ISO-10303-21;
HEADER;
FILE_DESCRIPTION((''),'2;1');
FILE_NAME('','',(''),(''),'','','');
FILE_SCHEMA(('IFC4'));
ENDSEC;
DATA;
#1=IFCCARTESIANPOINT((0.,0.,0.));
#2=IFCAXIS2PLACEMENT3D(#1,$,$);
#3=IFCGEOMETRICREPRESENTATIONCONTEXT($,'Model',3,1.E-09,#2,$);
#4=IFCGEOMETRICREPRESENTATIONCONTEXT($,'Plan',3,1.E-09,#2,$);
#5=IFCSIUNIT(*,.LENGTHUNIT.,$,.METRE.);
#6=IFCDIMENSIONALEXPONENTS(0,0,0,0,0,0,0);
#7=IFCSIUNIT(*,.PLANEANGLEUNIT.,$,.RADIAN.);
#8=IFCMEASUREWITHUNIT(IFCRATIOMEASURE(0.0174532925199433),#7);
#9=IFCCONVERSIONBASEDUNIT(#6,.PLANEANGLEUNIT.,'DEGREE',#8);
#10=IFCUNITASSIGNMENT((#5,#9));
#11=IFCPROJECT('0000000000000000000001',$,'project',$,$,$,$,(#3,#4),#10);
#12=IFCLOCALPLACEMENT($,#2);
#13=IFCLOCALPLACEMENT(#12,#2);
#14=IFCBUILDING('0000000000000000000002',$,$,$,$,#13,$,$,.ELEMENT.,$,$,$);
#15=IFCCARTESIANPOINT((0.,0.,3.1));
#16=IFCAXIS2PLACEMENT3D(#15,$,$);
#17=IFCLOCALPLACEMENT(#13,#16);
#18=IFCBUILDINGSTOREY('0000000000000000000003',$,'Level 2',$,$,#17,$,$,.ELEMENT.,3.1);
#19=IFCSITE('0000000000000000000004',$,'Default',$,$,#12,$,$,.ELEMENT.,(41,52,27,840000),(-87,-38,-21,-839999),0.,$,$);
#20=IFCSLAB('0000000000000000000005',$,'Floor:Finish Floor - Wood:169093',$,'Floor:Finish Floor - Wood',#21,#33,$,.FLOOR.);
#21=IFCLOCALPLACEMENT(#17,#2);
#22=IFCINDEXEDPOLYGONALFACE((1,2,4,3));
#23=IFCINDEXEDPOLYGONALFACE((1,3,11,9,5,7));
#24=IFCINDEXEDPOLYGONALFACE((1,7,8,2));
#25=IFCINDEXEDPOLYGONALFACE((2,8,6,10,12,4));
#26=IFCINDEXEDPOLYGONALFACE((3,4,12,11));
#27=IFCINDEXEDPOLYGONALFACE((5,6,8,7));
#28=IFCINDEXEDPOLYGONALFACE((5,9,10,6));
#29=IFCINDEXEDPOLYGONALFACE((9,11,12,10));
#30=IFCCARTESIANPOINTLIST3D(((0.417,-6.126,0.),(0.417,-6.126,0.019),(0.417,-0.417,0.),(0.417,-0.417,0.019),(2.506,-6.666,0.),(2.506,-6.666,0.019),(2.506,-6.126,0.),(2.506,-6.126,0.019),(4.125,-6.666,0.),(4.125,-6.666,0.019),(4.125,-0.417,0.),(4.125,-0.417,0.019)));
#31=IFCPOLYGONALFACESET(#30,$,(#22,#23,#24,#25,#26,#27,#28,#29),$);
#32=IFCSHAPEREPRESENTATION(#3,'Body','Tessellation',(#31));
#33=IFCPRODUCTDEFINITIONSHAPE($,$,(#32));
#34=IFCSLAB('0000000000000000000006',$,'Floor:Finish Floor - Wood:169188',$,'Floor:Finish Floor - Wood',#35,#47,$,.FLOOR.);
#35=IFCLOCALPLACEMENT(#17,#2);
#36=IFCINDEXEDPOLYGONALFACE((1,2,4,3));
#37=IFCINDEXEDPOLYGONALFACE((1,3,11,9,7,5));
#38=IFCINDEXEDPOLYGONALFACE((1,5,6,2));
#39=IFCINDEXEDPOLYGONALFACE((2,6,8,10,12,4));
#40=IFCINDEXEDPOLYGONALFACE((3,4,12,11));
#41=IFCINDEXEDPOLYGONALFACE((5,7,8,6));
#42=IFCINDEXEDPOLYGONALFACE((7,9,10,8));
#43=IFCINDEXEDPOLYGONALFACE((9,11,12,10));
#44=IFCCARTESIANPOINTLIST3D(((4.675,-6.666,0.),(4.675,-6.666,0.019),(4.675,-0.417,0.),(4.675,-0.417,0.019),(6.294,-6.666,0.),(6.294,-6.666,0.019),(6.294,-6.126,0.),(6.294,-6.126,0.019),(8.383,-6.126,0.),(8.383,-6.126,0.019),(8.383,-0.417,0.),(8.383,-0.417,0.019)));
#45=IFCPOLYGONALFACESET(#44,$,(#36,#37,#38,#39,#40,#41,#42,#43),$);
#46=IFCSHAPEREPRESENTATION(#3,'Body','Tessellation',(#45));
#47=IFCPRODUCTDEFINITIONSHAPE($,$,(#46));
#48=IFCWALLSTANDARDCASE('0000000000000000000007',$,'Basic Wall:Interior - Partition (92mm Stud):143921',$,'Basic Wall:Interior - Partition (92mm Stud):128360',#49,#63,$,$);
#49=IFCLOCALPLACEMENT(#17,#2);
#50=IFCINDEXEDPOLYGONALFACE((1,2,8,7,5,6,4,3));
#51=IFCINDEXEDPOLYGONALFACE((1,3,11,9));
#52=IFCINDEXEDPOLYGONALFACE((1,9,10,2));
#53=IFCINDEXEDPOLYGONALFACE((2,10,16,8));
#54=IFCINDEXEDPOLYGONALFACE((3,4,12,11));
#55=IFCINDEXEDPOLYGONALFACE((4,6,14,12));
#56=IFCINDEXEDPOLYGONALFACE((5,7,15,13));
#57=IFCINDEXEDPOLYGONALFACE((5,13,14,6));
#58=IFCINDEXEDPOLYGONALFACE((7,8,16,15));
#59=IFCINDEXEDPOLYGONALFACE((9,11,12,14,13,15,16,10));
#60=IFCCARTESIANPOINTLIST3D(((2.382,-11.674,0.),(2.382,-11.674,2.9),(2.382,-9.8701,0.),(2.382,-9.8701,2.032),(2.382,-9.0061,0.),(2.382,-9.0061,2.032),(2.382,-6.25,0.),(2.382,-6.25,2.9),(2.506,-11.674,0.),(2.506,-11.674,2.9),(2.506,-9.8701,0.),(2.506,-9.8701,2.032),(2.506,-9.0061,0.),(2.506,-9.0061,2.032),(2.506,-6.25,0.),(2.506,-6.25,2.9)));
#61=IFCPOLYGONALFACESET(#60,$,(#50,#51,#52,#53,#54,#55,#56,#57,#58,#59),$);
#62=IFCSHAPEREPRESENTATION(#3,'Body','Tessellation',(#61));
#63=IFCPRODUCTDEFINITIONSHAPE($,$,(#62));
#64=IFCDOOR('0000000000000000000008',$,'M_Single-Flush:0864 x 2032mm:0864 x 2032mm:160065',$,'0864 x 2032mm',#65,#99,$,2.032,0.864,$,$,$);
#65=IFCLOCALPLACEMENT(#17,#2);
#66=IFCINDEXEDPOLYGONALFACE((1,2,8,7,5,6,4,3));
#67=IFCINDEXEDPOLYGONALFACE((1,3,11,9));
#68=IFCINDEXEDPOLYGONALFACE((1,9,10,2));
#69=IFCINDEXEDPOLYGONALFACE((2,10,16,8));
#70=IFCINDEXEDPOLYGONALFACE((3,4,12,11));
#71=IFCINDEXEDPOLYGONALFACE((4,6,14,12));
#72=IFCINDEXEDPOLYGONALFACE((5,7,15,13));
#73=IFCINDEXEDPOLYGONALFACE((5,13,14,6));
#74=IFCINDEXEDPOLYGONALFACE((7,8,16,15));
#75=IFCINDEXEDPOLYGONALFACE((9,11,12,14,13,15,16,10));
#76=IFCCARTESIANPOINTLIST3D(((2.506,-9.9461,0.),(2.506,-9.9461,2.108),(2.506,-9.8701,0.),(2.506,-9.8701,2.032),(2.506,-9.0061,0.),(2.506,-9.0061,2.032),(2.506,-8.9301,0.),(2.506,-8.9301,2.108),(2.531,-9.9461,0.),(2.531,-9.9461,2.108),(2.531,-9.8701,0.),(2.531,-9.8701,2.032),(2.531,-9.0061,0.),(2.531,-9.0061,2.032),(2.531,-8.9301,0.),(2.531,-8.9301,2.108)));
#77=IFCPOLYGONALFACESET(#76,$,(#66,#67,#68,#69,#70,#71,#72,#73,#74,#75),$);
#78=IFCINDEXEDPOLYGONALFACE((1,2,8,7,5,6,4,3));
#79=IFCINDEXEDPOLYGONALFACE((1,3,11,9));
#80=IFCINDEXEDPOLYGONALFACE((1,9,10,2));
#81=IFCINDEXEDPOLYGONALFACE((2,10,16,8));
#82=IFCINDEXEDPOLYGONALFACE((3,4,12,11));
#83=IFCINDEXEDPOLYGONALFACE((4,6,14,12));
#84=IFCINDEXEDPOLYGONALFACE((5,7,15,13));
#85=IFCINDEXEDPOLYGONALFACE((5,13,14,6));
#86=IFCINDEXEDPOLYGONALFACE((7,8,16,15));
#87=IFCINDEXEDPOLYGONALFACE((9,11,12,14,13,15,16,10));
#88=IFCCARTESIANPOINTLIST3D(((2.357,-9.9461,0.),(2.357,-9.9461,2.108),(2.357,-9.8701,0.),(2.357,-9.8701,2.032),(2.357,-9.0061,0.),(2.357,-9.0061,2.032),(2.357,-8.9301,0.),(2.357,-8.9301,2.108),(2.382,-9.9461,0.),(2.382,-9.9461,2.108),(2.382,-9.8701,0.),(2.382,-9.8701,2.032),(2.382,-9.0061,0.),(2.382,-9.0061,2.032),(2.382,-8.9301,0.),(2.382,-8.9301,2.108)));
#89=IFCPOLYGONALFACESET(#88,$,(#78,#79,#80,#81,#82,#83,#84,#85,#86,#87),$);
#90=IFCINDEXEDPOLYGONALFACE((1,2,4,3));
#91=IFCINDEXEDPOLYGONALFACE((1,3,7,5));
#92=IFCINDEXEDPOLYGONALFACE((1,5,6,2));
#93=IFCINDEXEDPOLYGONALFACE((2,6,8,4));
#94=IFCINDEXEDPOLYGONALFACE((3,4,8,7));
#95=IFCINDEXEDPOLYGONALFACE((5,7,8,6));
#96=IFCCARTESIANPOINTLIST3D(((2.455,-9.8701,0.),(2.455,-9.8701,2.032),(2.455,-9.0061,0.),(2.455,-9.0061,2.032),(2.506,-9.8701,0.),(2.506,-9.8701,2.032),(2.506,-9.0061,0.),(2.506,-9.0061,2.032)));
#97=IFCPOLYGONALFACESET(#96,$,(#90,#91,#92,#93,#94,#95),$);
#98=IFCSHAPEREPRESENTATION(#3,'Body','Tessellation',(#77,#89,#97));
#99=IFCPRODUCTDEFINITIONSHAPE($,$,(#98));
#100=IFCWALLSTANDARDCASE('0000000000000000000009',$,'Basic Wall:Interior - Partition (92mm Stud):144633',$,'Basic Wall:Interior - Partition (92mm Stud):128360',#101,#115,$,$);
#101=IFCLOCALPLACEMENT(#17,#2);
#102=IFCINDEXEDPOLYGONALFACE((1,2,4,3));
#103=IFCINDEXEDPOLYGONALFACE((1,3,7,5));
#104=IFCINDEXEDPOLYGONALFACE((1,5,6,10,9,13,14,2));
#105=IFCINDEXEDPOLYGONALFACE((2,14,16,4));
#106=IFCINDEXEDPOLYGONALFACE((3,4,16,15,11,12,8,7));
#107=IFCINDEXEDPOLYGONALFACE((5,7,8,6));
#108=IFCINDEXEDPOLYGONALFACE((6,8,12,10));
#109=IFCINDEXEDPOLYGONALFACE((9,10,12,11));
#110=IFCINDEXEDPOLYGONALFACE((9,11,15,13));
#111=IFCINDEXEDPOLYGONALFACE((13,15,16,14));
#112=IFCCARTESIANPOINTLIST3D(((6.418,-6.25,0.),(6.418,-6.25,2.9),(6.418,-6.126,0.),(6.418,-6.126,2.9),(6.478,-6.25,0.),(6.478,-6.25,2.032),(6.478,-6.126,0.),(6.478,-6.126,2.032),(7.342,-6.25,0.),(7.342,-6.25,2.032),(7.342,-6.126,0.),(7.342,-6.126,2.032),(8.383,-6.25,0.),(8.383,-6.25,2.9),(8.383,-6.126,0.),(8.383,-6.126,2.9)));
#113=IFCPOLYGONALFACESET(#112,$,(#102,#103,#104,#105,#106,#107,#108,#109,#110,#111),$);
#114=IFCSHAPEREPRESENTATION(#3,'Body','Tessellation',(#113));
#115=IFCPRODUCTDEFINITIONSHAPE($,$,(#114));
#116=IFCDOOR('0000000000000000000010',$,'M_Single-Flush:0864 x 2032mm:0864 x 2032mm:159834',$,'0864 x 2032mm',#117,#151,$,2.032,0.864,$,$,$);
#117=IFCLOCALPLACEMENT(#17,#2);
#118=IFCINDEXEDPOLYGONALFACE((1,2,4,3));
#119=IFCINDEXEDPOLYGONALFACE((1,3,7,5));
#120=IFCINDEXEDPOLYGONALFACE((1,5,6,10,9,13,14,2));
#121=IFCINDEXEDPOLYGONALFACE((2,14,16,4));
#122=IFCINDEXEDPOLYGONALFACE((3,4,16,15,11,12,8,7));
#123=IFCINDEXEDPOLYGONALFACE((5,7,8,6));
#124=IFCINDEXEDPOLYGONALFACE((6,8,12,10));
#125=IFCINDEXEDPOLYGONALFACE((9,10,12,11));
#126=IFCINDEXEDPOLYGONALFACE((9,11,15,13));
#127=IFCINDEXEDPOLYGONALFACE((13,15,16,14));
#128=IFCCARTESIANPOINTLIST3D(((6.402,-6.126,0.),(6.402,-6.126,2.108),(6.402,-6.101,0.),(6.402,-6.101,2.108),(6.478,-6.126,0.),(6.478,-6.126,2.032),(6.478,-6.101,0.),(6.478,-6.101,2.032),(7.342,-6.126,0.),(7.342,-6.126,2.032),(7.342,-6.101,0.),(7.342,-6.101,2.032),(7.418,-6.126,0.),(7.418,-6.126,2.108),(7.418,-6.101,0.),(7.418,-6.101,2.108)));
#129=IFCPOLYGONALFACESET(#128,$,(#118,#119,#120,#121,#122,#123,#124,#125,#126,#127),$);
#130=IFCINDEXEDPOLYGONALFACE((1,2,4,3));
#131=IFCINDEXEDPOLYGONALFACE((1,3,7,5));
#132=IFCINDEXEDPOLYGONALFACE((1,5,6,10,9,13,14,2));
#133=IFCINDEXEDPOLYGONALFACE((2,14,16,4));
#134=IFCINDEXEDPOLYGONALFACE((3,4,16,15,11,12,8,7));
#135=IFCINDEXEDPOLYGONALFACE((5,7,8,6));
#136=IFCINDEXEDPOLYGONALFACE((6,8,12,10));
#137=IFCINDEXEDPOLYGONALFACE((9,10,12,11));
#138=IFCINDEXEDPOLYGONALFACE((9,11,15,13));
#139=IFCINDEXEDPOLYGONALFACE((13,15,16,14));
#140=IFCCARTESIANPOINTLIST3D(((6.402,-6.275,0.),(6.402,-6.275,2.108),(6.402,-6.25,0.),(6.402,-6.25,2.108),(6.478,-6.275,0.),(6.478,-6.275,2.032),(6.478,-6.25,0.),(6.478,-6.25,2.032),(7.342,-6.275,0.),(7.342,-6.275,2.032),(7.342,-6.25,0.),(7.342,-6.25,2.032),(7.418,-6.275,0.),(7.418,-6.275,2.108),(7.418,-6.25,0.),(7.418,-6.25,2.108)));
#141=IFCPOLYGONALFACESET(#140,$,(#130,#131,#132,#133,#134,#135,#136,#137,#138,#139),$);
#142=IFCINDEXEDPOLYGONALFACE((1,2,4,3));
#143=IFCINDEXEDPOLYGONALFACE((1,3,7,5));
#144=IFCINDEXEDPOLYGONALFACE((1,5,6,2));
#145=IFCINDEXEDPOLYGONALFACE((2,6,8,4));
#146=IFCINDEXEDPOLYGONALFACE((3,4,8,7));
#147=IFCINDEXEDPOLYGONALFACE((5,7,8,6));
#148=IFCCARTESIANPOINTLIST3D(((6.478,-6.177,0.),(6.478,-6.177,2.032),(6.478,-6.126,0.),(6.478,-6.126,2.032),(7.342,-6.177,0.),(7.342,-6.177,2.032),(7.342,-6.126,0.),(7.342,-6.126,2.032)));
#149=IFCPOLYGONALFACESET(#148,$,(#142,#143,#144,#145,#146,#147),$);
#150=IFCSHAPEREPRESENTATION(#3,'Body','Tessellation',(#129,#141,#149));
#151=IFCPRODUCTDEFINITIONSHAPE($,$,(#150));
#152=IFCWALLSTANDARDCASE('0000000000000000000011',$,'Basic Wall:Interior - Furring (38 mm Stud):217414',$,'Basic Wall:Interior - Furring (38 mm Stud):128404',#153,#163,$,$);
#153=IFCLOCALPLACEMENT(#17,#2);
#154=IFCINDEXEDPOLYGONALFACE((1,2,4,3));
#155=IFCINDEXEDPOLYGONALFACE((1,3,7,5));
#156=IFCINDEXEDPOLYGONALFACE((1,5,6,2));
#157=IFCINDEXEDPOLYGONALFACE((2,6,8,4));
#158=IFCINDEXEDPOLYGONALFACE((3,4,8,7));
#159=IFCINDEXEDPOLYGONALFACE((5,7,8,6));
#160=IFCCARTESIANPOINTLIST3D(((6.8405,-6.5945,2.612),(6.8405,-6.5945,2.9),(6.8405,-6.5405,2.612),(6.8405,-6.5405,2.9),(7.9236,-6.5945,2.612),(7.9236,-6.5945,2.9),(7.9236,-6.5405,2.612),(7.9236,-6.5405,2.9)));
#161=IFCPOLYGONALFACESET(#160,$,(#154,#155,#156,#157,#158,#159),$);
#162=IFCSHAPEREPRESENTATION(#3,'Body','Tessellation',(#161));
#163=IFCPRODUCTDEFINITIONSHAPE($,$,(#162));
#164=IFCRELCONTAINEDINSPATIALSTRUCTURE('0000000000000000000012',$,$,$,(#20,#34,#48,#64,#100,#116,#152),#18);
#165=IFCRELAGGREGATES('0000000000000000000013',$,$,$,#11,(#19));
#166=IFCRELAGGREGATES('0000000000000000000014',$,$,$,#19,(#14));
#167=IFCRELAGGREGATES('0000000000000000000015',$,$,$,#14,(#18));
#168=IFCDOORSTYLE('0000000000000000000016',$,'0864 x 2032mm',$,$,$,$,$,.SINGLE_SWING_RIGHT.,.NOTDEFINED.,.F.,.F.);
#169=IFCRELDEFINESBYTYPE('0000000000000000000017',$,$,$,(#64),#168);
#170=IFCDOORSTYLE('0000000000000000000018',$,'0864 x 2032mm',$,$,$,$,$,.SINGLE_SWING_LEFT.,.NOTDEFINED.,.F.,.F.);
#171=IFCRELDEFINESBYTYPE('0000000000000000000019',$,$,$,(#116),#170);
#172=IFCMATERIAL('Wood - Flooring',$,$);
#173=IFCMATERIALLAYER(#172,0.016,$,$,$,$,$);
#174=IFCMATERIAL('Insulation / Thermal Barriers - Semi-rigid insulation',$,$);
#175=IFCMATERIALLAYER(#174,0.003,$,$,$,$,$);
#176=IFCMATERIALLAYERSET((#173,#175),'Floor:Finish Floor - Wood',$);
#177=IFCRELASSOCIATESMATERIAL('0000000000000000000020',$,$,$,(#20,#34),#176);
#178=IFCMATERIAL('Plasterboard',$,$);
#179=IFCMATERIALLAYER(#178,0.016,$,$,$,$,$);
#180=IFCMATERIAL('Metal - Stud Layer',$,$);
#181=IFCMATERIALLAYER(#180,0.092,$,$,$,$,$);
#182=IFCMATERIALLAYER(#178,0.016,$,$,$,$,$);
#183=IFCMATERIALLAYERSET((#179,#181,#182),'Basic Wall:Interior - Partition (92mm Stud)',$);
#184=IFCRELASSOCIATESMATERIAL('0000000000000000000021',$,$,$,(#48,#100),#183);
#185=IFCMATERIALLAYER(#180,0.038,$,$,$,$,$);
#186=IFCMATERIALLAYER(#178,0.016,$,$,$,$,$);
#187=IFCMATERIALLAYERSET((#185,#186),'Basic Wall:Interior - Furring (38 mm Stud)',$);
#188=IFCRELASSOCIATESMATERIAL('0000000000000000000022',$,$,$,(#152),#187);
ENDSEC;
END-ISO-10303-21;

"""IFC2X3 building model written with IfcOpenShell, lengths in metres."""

from ifc_helpers import new_model, entity, si_unit, converted_unit, frame, frame_2d, origin, origin_2d_with_axis, place, context, project, spatial, polyline, rectangle, outline, extrude, source, transform, mapped, material, layer, layer_set, layer_usage, type_object, type_shapes, element, fill, save


model = new_model("IFC2X3")

# Units and contexts
model_context = context("Model", 3, precision=1e-09, world=origin())
plan_context = context("Plan", 3, precision=1e-09, world=origin())
ifc_project = project(units=[si_unit("LENGTHUNIT", "METRE"), converted_unit("PLANEANGLEUNIT", "DEGREE", entity("IfcRatioMeasure", 0.0174532925199433), si_unit("PLANEANGLEUNIT", "RADIAN"), dimensions=[0, 0, 0, 0, 0, 0, 0])], contexts=[model_context, plan_context])

# Site, building, storey
site_placement = place(None, origin())
site = spatial("IfcSite", under=ifc_project, at=site_placement, Name="Default", CompositionType="ELEMENT", RefLatitude=(41, 52, 27, 840000), RefLongitude=(-87, -38, -21, -839999), RefElevation=0.0)
building_placement = place(site_placement, origin())
building = spatial("IfcBuilding", under=site, at=building_placement, CompositionType="ELEMENT")
storey_placement = place(building_placement, frame((0.0, 0.0, 3.1)))
storey = spatial("IfcBuildingStorey", under=building, at=storey_placement, Name="Level 2", CompositionType="ELEMENT", Elevation=3.1)

# Slabs
ifc_material_1 = material(Name="Wood - Flooring")
ifc_layer_1 = layer(ifc_material_1, 0.016)
ifc_material_2 = material(Name="Insulation / Thermal Barriers - Semi-rigid insulation")
ifc_layer_2 = layer(ifc_material_2, 0.003)
ifc_layer_set_1 = layer_set([ifc_layer_1, ifc_layer_2], Name="Floor:Finish Floor - Wood")
ifc_layer_usage_1 = layer_usage(ifc_layer_set_1, "AXIS3", "POSITIVE", 0.0)
slab_1_placement = place(storey_placement, frame((0.417, -6.666, 0.0)))
element("IfcSlab", 1, at=slab_1_placement, inside=storey, material=ifc_layer_usage_1, Name="Floor:Finish Floor - Wood:169093", ObjectType="Floor:Finish Floor - Wood", PredefinedType="FLOOR", context=model_context, shape_type="SweptSolid", body=[
    extrude(outline(polyline([(1.854, 3.1245), (-1.854, 3.1245), (-1.854, -3.1245), (-0.235, -3.1245), (-0.235, -2.5845), (1.854, -2.5845), (1.854, 3.1245)])), frame((1.854, 3.1245, 0.019), z_axis=(0.0, 0.0, -1.0), x_axis=(-1.0, 0.0, 0.0)), (0.0, 0.0, 1.0), 0.019),
])
ifc_layer_usage_2 = layer_usage(ifc_layer_set_1, "AXIS3", "POSITIVE", 0.0)
slab_2_placement = place(storey_placement, frame((4.675, -6.666, 0.0)))
element("IfcSlab", 2, at=slab_2_placement, inside=storey, material=ifc_layer_usage_2, Name="Floor:Finish Floor - Wood:169188", ObjectType="Floor:Finish Floor - Wood", PredefinedType="FLOOR", context=model_context, shape_type="SweptSolid", body=[
    extrude(outline(polyline([(-1.854, 3.1245), (-1.854, -2.5845), (0.235, -2.5845), (0.235, -3.1245), (1.854, -3.1245), (1.854, 3.1245), (-1.854, 3.1245)])), frame((1.854, 3.1245, 0.019), z_axis=(0.0, 0.0, -1.0), x_axis=(-1.0, 0.0, 0.0)), (0.0, 0.0, 1.0), 0.019),
])

# Shared definitions
ifc_material_3 = material(Name="Metal - Stud Layer")
ifc_material_4 = material(Name="Plasterboard")

# Walls, openings, doors
ifc_layer_3 = layer(ifc_material_4, 0.016)
ifc_layer_4 = layer(ifc_material_3, 0.092)
ifc_layer_5 = layer(ifc_material_4, 0.016)
ifc_layer_set_2 = layer_set([ifc_layer_3, ifc_layer_4, ifc_layer_5], Name="Basic Wall:Interior - Partition (92mm Stud)")
ifc_layer_usage_3 = layer_usage(ifc_layer_set_2, "AXIS2", "NEGATIVE", 0.062)
wall_1_placement = place(storey_placement, frame((2.444, -6.25, 0.0), z_axis=(0.0, 0.0, 1.0), x_axis=(0.0, -1.0, 0.0)))
wall_1 = element("IfcWallStandardCase", 3, at=wall_1_placement, inside=storey, material=ifc_layer_usage_3, Name="Basic Wall:Interior - Partition (92mm Stud):143921", ObjectType="Basic Wall:Interior - Partition (92mm Stud):128360", context=model_context, shape_type="SweptSolid", body=[
    extrude(rectangle(XDim=5.424, YDim=0.124, at=frame_2d((2.712, 0.0), x_axis=(-1.0, 0.0))), origin(), (0.0, 0.0, 1.0), 2.9),
])
opening_1_placement = place(wall_1_placement, frame((2.7561, -0.062, 0.0)))
opening_1 = element("IfcOpeningElement", 4, at=opening_1_placement, cuts=wall_1, ObjectType="Opening", context=model_context, shape_type="SweptSolid", body=[
    extrude(rectangle(XDim=0.864, YDim=2.032, at=frame_2d((1.016, 0.432), x_axis=(0.0, 1.0))), frame((0.0, 0.0, 0.0), z_axis=(0.0, 1.0, 0.0), x_axis=(0.0, 0.0, 1.0)), (0.0, 0.0, 1.0), 0.124),
])
door_style_1 = type_object("IfcDoorStyle", Name="0864 x 2032mm", ConstructionType="NOTDEFINED", OperationType="SINGLE_SWING_RIGHT", ParameterTakesPrecedence=False, Sizeable=False)
shared_shape_1 = source(origin(), model_context, "Body", "SweptSolid", [
    extrude(outline(polyline([(-0.508, -1.073), (0.508, -1.073), (0.508, 1.035), (0.432, 1.035), (0.432, -0.997), (-0.432, -0.997), (-0.432, 1.035), (-0.508, 1.035), (-0.508, -1.073)])), frame((0.432, 0.124, 1.035), z_axis=(0.0, 1.0, 0.0), x_axis=(1.0, 0.0, 0.0)), (0.0, 0.0, 1.0), 0.025),
    extrude(outline(polyline([(-1.073, -0.508), (1.035, -0.508), (1.035, -0.432), (-0.997, -0.432), (-0.997, 0.432), (1.035, 0.432), (1.035, 0.508), (-1.073, 0.508), (-1.073, -0.508)])), frame((0.432, -0.025, 1.035), z_axis=(0.0, 1.0, 0.0), x_axis=(0.0, 0.0, -1.0)), (0.0, 0.0, 1.0), 0.025),
    extrude(rectangle(XDim=0.051, YDim=0.864, at=origin_2d_with_axis()), frame((0.432, 0.0985, 0.0), z_axis=(0.0, 0.0, 1.0), x_axis=(0.0, 1.0, 0.0)), (0.0, 0.0, 1.0), 2.032),
])
type_shapes(door_style_1, [shared_shape_1])
door_1_placement = place(opening_1_placement, origin())
door_1 = element("IfcDoor", 5, at=door_1_placement, inside=storey, type_object=door_style_1, Name="M_Single-Flush:0864 x 2032mm:0864 x 2032mm:160065", ObjectType="0864 x 2032mm", OverallHeight=2.032, OverallWidth=0.864, context=model_context, shape_type="MappedRepresentation", body=[
    mapped(shared_shape_1, transform((0.0, 0.0, 0.0), scale=1.0)),
])
fill(opening_1, door_1)
ifc_layer_usage_4 = layer_usage(ifc_layer_set_2, "AXIS2", "NEGATIVE", 0.062)
wall_2_placement = place(storey_placement, frame((6.418, -6.188, 0.0)))
wall_2 = element("IfcWallStandardCase", 6, at=wall_2_placement, inside=storey, material=ifc_layer_usage_4, Name="Basic Wall:Interior - Partition (92mm Stud):144633", ObjectType="Basic Wall:Interior - Partition (92mm Stud):128360", context=model_context, shape_type="SweptSolid", body=[
    extrude(rectangle(XDim=1.965, YDim=0.124, at=frame_2d((0.9825, 0.0), x_axis=(-1.0, 0.0))), origin(), (0.0, 0.0, 1.0), 2.9),
])
opening_2_placement = place(wall_2_placement, frame((0.06, -0.062, 0.0)))
opening_2 = element("IfcOpeningElement", 7, at=opening_2_placement, cuts=wall_2, ObjectType="Opening", context=model_context, shape_type="SweptSolid", body=[
    extrude(rectangle(XDim=0.864, YDim=2.032, at=frame_2d((1.016, 0.432), x_axis=(0.0, -1.0))), frame((0.0, 0.0, 0.0), z_axis=(0.0, 1.0, 0.0), x_axis=(0.0, 0.0, 1.0)), (0.0, 0.0, 1.0), 0.124),
])
door_style_2 = type_object("IfcDoorStyle", Name="0864 x 2032mm", ConstructionType="NOTDEFINED", OperationType="SINGLE_SWING_LEFT", ParameterTakesPrecedence=False, Sizeable=False)
shared_shape_2 = source(origin(), model_context, "Body", "SweptSolid", [
    extrude(outline(polyline([(-0.508, -1.073), (0.508, -1.073), (0.508, 1.035), (0.432, 1.035), (0.432, -0.997), (-0.432, -0.997), (-0.432, 1.035), (-0.508, 1.035), (-0.508, -1.073)])), frame((0.432, 0.149, 1.035), z_axis=(0.0, -1.0, 0.0), x_axis=(-1.0, 0.0, 0.0)), (0.0, 0.0, 1.0), 0.025),
    extrude(outline(polyline([(-1.073, -0.508), (1.035, -0.508), (1.035, -0.432), (-0.997, -0.432), (-0.997, 0.432), (1.035, 0.432), (1.035, 0.508), (-1.073, 0.508), (-1.073, -0.508)])), frame((0.432, 0.0, 1.035), z_axis=(0.0, -1.0, 0.0), x_axis=(0.0, 0.0, -1.0)), (0.0, 0.0, 1.0), 0.025),
    extrude(rectangle(XDim=0.864, YDim=0.051, at=origin_2d_with_axis()), frame((0.432, 0.0985, 0.0)), (0.0, 0.0, 1.0), 2.032),
])
type_shapes(door_style_2, [shared_shape_2])
door_2_placement = place(opening_2_placement, origin())
door_2 = element("IfcDoor", 8, at=door_2_placement, inside=storey, type_object=door_style_2, Name="M_Single-Flush:0864 x 2032mm:0864 x 2032mm:159834", ObjectType="0864 x 2032mm", OverallHeight=2.032, OverallWidth=0.864, context=model_context, shape_type="MappedRepresentation", body=[
    mapped(shared_shape_2, transform((0.0, 0.0, 0.0), scale=1.0)),
])
fill(opening_2, door_2)

# Wall
ifc_layer_6 = layer(ifc_material_3, 0.038)
ifc_layer_7 = layer(ifc_material_4, 0.016)
ifc_layer_set_3 = layer_set([ifc_layer_6, ifc_layer_7], Name="Basic Wall:Interior - Furring (38 mm Stud)")
ifc_layer_usage_5 = layer_usage(ifc_layer_set_3, "AXIS2", "NEGATIVE", 0.027)
wall_3_placement = place(storey_placement, frame((6.8405, -6.5675, 2.612)))
element("IfcWallStandardCase", 9, at=wall_3_placement, inside=storey, material=ifc_layer_usage_5, Name="Basic Wall:Interior - Furring (38 mm Stud):217414", ObjectType="Basic Wall:Interior - Furring (38 mm Stud):128404", context=model_context, shape_type="SweptSolid", body=[
    extrude(rectangle(XDim=1.0831, YDim=0.054, at=frame_2d((0.5415, 0.0), x_axis=(-1.0, 0.0))), origin(), (0.0, 0.0, 1.0), 0.288),
])

save(model, "model.ifc")
